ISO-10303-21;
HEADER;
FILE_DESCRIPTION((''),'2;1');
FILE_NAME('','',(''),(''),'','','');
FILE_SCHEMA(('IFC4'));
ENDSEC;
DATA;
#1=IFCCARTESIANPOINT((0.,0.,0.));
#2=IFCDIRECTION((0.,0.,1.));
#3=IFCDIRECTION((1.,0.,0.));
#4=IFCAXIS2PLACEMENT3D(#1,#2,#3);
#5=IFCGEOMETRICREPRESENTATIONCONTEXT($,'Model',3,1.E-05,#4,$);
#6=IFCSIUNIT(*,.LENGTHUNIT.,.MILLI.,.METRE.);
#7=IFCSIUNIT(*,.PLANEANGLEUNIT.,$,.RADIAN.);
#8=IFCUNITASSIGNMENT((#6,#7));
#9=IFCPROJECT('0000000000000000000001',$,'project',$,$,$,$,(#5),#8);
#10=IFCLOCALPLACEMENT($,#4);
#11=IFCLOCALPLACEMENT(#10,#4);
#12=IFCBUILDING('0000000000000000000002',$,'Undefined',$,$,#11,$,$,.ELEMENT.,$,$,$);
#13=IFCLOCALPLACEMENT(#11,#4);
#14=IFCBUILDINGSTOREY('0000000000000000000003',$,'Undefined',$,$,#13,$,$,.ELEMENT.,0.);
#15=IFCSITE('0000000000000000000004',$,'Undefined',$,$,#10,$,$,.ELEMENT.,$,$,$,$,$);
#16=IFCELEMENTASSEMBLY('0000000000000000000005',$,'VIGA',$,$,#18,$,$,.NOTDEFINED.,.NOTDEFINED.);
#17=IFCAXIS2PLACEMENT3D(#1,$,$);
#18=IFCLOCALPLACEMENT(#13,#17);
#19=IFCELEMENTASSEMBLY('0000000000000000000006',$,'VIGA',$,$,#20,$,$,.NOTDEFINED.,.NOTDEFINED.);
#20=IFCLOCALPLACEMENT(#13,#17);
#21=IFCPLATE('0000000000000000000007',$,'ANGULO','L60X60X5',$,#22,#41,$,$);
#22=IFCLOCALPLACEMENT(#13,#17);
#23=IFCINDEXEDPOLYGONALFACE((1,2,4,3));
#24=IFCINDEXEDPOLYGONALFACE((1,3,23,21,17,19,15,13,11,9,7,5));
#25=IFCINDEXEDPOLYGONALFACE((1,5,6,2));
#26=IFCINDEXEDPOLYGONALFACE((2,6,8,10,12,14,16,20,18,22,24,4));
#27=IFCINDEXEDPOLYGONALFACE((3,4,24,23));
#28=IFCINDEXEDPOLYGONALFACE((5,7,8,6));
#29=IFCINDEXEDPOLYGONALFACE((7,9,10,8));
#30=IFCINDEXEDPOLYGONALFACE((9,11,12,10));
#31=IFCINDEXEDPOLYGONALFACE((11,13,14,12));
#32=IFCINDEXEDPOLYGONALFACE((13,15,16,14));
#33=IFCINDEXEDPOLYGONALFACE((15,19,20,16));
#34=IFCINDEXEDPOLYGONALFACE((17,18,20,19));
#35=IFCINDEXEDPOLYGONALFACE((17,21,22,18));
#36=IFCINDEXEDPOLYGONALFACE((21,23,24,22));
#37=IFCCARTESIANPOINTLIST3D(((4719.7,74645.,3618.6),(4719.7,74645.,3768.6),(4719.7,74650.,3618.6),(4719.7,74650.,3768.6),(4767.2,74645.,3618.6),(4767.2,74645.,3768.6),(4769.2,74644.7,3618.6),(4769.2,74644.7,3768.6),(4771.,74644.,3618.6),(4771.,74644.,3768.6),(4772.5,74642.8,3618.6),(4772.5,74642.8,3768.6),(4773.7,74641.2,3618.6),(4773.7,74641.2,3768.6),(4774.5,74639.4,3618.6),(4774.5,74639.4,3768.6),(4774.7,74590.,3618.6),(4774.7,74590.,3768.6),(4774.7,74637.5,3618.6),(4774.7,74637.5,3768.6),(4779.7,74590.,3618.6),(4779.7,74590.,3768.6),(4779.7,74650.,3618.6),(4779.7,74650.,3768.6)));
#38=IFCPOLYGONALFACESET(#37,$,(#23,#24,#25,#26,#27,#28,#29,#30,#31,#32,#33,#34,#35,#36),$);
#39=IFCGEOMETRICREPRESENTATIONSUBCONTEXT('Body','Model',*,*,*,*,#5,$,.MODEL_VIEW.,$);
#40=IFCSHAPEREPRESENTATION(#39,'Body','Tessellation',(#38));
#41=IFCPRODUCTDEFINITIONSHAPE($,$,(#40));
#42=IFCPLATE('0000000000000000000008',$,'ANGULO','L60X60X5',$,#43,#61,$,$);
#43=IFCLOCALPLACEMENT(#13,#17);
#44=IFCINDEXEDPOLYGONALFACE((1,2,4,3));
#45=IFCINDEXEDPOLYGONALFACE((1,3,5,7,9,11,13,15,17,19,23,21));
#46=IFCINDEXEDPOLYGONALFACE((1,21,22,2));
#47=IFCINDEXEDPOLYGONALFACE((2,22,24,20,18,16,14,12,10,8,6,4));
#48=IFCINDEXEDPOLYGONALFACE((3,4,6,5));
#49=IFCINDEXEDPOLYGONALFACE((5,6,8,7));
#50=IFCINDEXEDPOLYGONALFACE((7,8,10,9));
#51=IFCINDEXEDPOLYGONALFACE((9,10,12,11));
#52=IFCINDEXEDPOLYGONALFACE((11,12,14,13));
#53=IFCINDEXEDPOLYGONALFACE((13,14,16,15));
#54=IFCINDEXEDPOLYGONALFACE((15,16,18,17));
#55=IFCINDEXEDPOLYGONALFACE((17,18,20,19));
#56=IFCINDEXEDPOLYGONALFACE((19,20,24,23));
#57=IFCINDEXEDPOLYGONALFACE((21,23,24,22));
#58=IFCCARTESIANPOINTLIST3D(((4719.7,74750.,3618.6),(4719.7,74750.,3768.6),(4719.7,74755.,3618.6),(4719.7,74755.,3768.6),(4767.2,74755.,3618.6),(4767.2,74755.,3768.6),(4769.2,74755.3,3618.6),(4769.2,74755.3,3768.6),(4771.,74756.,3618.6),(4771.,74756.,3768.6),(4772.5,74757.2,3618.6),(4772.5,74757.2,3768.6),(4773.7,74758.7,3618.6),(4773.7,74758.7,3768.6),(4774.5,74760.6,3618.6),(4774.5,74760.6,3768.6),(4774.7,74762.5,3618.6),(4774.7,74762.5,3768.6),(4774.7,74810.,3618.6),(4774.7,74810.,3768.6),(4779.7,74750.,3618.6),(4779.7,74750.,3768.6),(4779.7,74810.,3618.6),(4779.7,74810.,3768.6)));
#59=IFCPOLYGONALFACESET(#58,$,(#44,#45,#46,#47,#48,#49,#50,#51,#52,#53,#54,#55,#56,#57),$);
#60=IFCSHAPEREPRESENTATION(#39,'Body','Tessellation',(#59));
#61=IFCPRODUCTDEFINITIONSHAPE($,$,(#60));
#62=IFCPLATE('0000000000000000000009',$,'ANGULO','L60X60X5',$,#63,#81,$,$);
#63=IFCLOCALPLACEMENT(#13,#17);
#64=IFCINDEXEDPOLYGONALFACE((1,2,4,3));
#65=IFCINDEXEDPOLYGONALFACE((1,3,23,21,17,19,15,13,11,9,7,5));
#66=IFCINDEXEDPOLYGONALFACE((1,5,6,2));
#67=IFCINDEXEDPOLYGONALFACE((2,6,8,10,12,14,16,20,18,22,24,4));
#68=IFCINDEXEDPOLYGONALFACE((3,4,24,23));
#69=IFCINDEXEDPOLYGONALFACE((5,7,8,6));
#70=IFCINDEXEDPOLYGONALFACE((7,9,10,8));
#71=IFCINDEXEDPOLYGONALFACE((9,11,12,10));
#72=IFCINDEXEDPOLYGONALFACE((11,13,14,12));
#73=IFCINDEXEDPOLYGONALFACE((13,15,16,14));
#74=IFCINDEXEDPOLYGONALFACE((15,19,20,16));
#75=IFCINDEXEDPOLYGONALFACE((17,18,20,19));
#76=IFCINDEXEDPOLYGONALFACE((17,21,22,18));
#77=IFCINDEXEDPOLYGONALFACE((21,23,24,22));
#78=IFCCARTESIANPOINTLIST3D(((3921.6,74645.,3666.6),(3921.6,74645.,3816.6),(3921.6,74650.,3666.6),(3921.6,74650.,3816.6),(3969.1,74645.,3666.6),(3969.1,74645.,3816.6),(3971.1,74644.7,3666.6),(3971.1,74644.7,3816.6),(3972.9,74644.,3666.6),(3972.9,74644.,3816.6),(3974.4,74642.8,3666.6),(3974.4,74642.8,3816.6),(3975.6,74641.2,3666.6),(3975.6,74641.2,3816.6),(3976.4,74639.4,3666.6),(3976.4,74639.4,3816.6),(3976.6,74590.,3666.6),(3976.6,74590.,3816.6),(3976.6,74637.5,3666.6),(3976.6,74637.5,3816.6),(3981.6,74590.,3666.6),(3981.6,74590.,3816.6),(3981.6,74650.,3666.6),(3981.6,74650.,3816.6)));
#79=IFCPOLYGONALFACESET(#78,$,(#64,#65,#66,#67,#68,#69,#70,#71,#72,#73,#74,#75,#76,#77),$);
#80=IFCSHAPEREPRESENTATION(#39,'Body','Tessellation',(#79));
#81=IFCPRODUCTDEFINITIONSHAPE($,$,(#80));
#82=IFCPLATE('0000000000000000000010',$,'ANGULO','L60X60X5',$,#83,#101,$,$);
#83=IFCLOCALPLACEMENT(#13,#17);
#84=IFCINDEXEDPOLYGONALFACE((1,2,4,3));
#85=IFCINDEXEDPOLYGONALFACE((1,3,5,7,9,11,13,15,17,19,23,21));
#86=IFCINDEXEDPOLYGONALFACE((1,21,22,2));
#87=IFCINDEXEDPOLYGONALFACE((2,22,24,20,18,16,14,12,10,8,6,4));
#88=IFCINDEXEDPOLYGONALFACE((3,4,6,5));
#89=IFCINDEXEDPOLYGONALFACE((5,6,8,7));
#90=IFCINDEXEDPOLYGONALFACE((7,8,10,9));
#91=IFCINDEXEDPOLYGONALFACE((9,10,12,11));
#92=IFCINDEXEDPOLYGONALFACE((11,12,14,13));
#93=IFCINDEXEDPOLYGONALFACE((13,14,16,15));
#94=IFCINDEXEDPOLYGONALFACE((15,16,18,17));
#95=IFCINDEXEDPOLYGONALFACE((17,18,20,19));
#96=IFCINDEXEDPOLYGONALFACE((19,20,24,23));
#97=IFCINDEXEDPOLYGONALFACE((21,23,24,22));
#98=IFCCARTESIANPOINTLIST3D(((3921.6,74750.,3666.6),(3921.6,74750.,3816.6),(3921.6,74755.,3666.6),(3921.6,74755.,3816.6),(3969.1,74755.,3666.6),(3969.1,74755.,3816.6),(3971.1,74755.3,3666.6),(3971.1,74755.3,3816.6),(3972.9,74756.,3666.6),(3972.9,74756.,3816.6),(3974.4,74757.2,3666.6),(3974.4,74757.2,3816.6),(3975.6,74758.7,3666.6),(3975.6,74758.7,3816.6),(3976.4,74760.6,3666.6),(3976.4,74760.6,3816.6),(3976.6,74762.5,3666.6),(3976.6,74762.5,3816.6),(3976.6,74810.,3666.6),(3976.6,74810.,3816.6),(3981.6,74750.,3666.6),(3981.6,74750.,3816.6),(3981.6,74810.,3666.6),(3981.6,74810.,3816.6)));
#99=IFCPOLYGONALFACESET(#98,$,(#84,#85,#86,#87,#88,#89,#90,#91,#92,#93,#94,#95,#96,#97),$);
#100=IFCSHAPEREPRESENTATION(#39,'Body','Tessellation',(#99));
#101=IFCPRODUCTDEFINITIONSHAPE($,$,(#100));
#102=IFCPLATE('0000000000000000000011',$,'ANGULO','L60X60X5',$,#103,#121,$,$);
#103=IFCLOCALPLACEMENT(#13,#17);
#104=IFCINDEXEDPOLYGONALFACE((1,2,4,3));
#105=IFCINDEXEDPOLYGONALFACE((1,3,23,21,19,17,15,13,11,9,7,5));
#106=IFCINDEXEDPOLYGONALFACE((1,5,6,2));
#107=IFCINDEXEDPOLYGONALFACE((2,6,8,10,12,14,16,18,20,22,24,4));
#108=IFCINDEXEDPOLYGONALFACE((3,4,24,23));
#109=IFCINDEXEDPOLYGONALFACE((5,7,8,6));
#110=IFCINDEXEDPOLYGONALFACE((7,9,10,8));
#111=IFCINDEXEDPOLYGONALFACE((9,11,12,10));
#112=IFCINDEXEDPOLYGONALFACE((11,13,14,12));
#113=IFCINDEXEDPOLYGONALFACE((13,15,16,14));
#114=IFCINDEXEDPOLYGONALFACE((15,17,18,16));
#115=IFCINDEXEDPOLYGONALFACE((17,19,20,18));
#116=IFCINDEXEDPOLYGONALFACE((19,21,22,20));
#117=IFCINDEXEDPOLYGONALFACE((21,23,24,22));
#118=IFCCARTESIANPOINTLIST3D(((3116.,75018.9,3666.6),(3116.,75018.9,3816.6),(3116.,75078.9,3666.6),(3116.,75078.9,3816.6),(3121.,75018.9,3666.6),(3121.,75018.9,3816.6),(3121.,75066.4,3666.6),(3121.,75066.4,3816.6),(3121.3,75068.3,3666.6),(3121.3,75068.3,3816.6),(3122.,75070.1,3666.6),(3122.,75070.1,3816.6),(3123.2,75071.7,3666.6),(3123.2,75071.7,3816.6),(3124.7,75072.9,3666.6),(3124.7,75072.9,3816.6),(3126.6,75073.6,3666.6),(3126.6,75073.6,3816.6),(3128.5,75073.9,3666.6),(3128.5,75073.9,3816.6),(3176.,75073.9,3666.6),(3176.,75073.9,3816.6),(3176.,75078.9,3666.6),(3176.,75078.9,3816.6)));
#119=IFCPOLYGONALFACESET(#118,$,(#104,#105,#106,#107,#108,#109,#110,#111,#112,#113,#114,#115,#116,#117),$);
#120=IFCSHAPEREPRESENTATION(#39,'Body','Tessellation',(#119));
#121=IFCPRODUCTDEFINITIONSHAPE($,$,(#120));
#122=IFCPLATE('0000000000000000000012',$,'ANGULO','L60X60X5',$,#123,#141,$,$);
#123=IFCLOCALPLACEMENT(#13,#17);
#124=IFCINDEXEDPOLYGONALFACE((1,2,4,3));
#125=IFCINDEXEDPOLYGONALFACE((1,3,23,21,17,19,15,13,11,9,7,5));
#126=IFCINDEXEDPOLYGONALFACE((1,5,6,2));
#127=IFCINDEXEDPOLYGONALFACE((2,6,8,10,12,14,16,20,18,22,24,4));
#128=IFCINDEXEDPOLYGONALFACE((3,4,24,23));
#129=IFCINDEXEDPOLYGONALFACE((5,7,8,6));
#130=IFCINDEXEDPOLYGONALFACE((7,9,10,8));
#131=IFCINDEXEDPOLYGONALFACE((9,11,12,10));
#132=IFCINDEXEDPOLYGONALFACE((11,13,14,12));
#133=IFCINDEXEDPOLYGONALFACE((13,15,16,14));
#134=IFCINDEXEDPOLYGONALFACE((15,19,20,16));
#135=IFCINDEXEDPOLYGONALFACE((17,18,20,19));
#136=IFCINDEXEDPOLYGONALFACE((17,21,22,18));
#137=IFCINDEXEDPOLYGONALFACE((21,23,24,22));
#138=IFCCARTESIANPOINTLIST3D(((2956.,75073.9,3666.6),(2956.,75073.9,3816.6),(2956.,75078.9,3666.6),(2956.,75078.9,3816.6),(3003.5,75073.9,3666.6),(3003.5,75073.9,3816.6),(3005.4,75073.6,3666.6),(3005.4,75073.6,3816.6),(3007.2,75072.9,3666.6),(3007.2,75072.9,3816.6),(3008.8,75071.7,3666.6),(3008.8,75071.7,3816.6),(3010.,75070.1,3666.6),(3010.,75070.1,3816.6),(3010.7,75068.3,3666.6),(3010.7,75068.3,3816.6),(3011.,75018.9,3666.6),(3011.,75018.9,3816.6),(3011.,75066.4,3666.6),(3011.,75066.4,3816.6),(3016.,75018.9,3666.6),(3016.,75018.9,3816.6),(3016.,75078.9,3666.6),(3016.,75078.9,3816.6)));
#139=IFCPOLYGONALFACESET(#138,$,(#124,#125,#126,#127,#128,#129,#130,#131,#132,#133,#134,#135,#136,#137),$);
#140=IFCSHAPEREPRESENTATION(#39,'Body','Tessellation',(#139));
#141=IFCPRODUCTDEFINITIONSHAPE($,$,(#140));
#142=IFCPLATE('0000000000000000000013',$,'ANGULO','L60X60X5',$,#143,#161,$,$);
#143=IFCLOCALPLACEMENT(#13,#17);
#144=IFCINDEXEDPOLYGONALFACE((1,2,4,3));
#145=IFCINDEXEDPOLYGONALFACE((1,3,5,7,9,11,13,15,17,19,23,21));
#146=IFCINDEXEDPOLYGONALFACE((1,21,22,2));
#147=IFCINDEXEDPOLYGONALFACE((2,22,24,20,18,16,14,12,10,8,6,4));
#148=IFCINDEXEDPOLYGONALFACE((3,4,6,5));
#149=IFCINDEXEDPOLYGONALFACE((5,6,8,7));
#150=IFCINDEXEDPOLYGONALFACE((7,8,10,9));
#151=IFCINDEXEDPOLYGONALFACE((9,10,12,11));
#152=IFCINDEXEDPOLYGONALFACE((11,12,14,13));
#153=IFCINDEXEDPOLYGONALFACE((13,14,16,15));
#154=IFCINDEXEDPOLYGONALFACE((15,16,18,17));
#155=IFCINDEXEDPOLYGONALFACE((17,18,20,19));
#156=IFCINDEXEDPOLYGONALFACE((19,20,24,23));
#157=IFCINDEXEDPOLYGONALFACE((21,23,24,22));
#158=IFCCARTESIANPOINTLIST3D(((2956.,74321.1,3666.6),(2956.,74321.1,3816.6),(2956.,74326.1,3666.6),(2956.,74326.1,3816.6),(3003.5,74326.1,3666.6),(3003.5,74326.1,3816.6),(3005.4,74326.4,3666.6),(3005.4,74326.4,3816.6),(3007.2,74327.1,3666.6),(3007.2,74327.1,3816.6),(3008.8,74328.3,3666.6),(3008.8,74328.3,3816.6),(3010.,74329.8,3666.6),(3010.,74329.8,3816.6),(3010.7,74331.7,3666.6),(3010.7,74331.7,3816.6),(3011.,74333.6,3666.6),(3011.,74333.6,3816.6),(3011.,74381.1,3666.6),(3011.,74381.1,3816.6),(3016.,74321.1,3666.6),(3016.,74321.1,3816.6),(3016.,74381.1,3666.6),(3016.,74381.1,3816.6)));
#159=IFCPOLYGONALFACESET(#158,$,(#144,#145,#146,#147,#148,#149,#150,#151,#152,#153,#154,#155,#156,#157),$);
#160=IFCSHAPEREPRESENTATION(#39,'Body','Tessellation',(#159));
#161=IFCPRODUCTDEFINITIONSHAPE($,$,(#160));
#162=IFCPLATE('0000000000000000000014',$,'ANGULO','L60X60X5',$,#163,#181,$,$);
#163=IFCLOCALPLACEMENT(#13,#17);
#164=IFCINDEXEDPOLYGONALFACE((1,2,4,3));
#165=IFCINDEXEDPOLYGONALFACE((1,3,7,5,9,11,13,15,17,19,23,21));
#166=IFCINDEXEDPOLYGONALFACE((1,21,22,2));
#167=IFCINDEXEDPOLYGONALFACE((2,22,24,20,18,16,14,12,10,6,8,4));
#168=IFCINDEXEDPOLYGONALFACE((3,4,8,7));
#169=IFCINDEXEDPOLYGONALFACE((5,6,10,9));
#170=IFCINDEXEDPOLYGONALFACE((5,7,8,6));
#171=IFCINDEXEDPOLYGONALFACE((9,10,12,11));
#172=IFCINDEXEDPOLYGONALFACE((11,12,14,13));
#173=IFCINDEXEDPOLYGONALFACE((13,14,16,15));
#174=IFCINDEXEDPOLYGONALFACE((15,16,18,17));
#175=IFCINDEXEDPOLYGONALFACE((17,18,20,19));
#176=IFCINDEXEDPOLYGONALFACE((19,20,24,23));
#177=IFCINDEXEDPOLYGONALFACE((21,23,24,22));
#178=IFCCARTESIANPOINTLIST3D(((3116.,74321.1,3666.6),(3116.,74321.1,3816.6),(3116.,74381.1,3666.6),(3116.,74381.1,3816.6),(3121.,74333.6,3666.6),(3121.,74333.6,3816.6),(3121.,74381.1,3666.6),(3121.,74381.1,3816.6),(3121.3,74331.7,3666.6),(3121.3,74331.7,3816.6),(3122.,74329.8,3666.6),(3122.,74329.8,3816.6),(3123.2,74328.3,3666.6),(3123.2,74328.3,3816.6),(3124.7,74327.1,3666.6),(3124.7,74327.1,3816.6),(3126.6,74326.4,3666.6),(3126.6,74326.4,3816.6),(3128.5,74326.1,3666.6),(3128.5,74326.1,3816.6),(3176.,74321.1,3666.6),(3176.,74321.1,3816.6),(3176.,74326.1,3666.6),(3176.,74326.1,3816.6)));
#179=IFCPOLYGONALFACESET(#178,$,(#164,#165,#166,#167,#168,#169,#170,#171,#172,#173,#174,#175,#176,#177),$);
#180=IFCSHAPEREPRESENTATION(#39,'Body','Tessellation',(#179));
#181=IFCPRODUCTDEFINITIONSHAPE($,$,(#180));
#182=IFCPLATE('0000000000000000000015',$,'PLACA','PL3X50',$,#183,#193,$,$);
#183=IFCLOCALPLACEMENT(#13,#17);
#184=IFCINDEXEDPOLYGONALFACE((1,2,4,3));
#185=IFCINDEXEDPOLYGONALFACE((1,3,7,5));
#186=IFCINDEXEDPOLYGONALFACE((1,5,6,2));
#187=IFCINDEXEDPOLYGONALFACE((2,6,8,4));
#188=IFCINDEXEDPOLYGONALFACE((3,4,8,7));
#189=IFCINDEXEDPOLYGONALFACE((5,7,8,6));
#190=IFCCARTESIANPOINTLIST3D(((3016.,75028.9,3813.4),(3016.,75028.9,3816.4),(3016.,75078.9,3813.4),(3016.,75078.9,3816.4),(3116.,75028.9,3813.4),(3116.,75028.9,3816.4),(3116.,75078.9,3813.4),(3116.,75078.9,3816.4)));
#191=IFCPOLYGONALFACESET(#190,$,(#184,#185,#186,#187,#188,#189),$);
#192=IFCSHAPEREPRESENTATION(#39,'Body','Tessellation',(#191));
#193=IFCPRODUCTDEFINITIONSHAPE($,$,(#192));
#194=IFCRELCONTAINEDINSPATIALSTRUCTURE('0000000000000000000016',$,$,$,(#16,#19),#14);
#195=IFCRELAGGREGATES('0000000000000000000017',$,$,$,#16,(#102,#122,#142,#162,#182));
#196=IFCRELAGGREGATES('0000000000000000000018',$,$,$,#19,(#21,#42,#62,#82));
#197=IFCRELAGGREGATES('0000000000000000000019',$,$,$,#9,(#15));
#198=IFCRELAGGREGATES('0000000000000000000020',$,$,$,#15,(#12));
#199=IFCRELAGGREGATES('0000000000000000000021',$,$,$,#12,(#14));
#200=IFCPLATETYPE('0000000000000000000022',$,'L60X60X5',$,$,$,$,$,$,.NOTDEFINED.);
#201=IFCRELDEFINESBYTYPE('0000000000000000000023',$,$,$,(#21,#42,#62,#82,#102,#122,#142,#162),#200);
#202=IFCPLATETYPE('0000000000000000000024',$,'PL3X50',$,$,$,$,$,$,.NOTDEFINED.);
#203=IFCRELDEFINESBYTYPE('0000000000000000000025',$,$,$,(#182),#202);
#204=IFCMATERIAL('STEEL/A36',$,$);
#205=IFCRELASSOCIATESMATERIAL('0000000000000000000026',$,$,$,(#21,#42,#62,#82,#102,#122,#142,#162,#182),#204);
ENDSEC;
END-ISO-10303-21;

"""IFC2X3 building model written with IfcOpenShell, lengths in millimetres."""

from ifc_helpers import new_model, si_unit, frame, origin_with_axes, origin_2d_with_axis, place, context, subcontext, project, spatial, polyline, l_section, outline, extrude, material, type_object, element, aggregate, save


model = new_model("IFC2X3")

# Units and contexts
model_context = context("Model", 3, precision=1e-05, world=origin_with_axes())
body_context = subcontext(model_context, "Body", "Model", "MODEL_VIEW")
ifc_project = project(units=[si_unit("LENGTHUNIT", "METRE", prefix="MILLI"), si_unit("PLANEANGLEUNIT", "RADIAN")], contexts=[model_context])

# Site, building, storey
site_placement = place(None, origin_with_axes())
site = spatial("IfcSite", under=ifc_project, at=site_placement, Name="Undefined", CompositionType="ELEMENT")
building_placement = place(site_placement, origin_with_axes())
building = spatial("IfcBuilding", under=site, at=building_placement, Name="Undefined", CompositionType="ELEMENT")
storey_placement = place(building_placement, origin_with_axes())
storey = spatial("IfcBuildingStorey", under=building, at=storey_placement, Name="Undefined", CompositionType="ELEMENT", Elevation=0.0)

# Element assembly
assembly_1_placement = place(storey_placement, origin_with_axes())
assembly_1 = element("IfcElementAssembly", 1, at=assembly_1_placement, inside=storey, Name="VIGA", AssemblyPlace="NOTDEFINED", PredefinedType="NOTDEFINED")
ifc_material_1 = material(Name="STEEL/A36")

# Element assembly, plates
assembly_2_placement = place(storey_placement, origin_with_axes())
assembly_2 = element("IfcElementAssembly", 2, at=assembly_2_placement, inside=storey, Name="VIGA", AssemblyPlace="NOTDEFINED", PredefinedType="NOTDEFINED")
plate_type_1 = type_object("IfcPlateType", Name="L60X60X5", PredefinedType="NOTDEFINED")
plate_1_placement = place(assembly_2_placement, frame((4749.7, 74620.0, 3618.6), z_axis=(-1.0, 0.0, 0.0), x_axis=(0.0, 0.0, 1.0)))
plate_1 = element("IfcPlate", 3, at=plate_1_placement, type_object=plate_type_1, material=ifc_material_1, Name="ANGULO", Description="L60X60X5", context=body_context, shape_type="SweptSolid", body=[
    extrude(l_section(Depth=60.0, Width=60.0, Thickness=5.0, FilletRadius=7.5, at=origin_2d_with_axis()), frame((150.0, 0.0, 0.0), z_axis=(-1.0, 0.0, 0.0), x_axis=(0.0, -1.0, 0.0)), (0.0, 0.0, 1.0), 150.0),
])
plate_2_placement = place(assembly_2_placement, frame((4749.7, 74780.0, 3768.6), z_axis=(-1.0, 0.0, 0.0), x_axis=(0.0, 0.0, -1.0)))
plate_2 = element("IfcPlate", 4, at=plate_2_placement, type_object=plate_type_1, material=ifc_material_1, Name="ANGULO", Description="L60X60X5", context=body_context, shape_type="SweptSolid", body=[
    extrude(l_section(Depth=60.0, Width=60.0, Thickness=5.0, FilletRadius=7.5, at=origin_2d_with_axis()), frame((150.0, 0.0, 0.0), z_axis=(-1.0, 0.0, 0.0), x_axis=(0.0, -1.0, 0.0)), (0.0, 0.0, 1.0), 150.0),
])
plate_3_placement = place(assembly_2_placement, frame((3951.6, 74620.0, 3666.6), z_axis=(-1.0, 0.0, 0.0), x_axis=(0.0, 0.0, 1.0)))
plate_3 = element("IfcPlate", 5, at=plate_3_placement, type_object=plate_type_1, material=ifc_material_1, Name="ANGULO", Description="L60X60X5", context=body_context, shape_type="SweptSolid", body=[
    extrude(l_section(Depth=60.0, Width=60.0, Thickness=5.0, FilletRadius=7.5, at=origin_2d_with_axis()), frame((150.0, 0.0, 0.0), z_axis=(-1.0, 0.0, 0.0), x_axis=(0.0, -1.0, 0.0)), (0.0, 0.0, 1.0), 150.0),
])
plate_4_placement = place(assembly_2_placement, frame((3951.6, 74780.0, 3816.6), z_axis=(-1.0, 0.0, 0.0), x_axis=(0.0, 0.0, -1.0)))
plate_4 = element("IfcPlate", 6, at=plate_4_placement, type_object=plate_type_1, material=ifc_material_1, Name="ANGULO", Description="L60X60X5", context=body_context, shape_type="SweptSolid", body=[
    extrude(l_section(Depth=60.0, Width=60.0, Thickness=5.0, FilletRadius=7.5, at=origin_2d_with_axis()), frame((150.0, 0.0, 0.0), z_axis=(-1.0, 0.0, 0.0), x_axis=(0.0, -1.0, 0.0)), (0.0, 0.0, 1.0), 150.0),
])

# Plates
plate_5_placement = place(assembly_1_placement, frame((3146.0, 75048.9, 3666.6), z_axis=(0.0, -1.0, 0.0), x_axis=(0.0, 0.0, 1.0)))
plate_5 = element("IfcPlate", 7, at=plate_5_placement, type_object=plate_type_1, material=ifc_material_1, Name="ANGULO", Description="L60X60X5", context=body_context, shape_type="SweptSolid", body=[
    extrude(l_section(Depth=60.0, Width=60.0, Thickness=5.0, FilletRadius=7.5, at=origin_2d_with_axis()), frame((150.0, 0.0, 0.0), z_axis=(-1.0, 0.0, 0.0), x_axis=(0.0, -1.0, 0.0)), (0.0, 0.0, 1.0), 150.0),
])
plate_6_placement = place(assembly_1_placement, frame((2986.0, 75048.9, 3816.6), z_axis=(0.0, -1.0, 0.0), x_axis=(0.0, 0.0, -1.0)))
plate_6 = element("IfcPlate", 8, at=plate_6_placement, type_object=plate_type_1, material=ifc_material_1, Name="ANGULO", Description="L60X60X5", context=body_context, shape_type="SweptSolid", body=[
    extrude(l_section(Depth=60.0, Width=60.0, Thickness=5.0, FilletRadius=7.5, at=origin_2d_with_axis()), frame((150.0, 0.0, 0.0), z_axis=(-1.0, 0.0, 0.0), x_axis=(0.0, -1.0, 0.0)), (0.0, 0.0, 1.0), 150.0),
])
plate_7_placement = place(assembly_1_placement, frame((2986.0, 74351.1, 3666.6), z_axis=(0.0, 1.0, 0.0), x_axis=(0.0, 0.0, 1.0)))
plate_7 = element("IfcPlate", 9, at=plate_7_placement, type_object=plate_type_1, material=ifc_material_1, Name="ANGULO", Description="L60X60X5", context=body_context, shape_type="SweptSolid", body=[
    extrude(l_section(Depth=60.0, Width=60.0, Thickness=5.0, FilletRadius=7.5, at=origin_2d_with_axis()), frame((150.0, 0.0, 0.0), z_axis=(-1.0, 0.0, 0.0), x_axis=(0.0, -1.0, 0.0)), (0.0, 0.0, 1.0), 150.0),
])
plate_8_placement = place(assembly_1_placement, frame((3146.0, 74351.1, 3816.6), z_axis=(0.0, 1.0, 0.0), x_axis=(0.0, 0.0, -1.0)))
plate_8 = element("IfcPlate", 10, at=plate_8_placement, type_object=plate_type_1, material=ifc_material_1, Name="ANGULO", Description="L60X60X5", context=body_context, shape_type="SweptSolid", body=[
    extrude(l_section(Depth=60.0, Width=60.0, Thickness=5.0, FilletRadius=7.5, at=origin_2d_with_axis()), frame((150.0, 0.0, 0.0), z_axis=(-1.0, 0.0, 0.0), x_axis=(0.0, -1.0, 0.0)), (0.0, 0.0, 1.0), 150.0),
])
plate_type_2 = type_object("IfcPlateType", Name="PL3X50", PredefinedType="NOTDEFINED")
plate_9_placement = place(assembly_1_placement, frame((3016.0, 75028.9, 3814.9), z_axis=(0.0, 0.0, -1.0), x_axis=(0.0, 1.0, 0.0)))
plate_9 = element("IfcPlate", 11, at=plate_9_placement, type_object=plate_type_2, material=ifc_material_1, Name="PLACA", Description="PL3X50", context=body_context, shape_type="SweptSolid", body=[
    extrude(outline(polyline([(0.0, 0.0), (50.0, 0.0), (50.0, 100.0), (0.0, 100.0), (0.0, 0.0)])), frame((0.0, 0.0, -1.5), z_axis=(0.0, 0.0, 1.0), x_axis=(1.0, 0.0, 0.0)), (0.0, 0.0, 1.0), 3.0),
])
aggregate(assembly_1, [plate_5, plate_6, plate_7, plate_8, plate_9])
aggregate(assembly_2, [plate_1, plate_2, plate_3, plate_4])

save(model, "model.ifc")
